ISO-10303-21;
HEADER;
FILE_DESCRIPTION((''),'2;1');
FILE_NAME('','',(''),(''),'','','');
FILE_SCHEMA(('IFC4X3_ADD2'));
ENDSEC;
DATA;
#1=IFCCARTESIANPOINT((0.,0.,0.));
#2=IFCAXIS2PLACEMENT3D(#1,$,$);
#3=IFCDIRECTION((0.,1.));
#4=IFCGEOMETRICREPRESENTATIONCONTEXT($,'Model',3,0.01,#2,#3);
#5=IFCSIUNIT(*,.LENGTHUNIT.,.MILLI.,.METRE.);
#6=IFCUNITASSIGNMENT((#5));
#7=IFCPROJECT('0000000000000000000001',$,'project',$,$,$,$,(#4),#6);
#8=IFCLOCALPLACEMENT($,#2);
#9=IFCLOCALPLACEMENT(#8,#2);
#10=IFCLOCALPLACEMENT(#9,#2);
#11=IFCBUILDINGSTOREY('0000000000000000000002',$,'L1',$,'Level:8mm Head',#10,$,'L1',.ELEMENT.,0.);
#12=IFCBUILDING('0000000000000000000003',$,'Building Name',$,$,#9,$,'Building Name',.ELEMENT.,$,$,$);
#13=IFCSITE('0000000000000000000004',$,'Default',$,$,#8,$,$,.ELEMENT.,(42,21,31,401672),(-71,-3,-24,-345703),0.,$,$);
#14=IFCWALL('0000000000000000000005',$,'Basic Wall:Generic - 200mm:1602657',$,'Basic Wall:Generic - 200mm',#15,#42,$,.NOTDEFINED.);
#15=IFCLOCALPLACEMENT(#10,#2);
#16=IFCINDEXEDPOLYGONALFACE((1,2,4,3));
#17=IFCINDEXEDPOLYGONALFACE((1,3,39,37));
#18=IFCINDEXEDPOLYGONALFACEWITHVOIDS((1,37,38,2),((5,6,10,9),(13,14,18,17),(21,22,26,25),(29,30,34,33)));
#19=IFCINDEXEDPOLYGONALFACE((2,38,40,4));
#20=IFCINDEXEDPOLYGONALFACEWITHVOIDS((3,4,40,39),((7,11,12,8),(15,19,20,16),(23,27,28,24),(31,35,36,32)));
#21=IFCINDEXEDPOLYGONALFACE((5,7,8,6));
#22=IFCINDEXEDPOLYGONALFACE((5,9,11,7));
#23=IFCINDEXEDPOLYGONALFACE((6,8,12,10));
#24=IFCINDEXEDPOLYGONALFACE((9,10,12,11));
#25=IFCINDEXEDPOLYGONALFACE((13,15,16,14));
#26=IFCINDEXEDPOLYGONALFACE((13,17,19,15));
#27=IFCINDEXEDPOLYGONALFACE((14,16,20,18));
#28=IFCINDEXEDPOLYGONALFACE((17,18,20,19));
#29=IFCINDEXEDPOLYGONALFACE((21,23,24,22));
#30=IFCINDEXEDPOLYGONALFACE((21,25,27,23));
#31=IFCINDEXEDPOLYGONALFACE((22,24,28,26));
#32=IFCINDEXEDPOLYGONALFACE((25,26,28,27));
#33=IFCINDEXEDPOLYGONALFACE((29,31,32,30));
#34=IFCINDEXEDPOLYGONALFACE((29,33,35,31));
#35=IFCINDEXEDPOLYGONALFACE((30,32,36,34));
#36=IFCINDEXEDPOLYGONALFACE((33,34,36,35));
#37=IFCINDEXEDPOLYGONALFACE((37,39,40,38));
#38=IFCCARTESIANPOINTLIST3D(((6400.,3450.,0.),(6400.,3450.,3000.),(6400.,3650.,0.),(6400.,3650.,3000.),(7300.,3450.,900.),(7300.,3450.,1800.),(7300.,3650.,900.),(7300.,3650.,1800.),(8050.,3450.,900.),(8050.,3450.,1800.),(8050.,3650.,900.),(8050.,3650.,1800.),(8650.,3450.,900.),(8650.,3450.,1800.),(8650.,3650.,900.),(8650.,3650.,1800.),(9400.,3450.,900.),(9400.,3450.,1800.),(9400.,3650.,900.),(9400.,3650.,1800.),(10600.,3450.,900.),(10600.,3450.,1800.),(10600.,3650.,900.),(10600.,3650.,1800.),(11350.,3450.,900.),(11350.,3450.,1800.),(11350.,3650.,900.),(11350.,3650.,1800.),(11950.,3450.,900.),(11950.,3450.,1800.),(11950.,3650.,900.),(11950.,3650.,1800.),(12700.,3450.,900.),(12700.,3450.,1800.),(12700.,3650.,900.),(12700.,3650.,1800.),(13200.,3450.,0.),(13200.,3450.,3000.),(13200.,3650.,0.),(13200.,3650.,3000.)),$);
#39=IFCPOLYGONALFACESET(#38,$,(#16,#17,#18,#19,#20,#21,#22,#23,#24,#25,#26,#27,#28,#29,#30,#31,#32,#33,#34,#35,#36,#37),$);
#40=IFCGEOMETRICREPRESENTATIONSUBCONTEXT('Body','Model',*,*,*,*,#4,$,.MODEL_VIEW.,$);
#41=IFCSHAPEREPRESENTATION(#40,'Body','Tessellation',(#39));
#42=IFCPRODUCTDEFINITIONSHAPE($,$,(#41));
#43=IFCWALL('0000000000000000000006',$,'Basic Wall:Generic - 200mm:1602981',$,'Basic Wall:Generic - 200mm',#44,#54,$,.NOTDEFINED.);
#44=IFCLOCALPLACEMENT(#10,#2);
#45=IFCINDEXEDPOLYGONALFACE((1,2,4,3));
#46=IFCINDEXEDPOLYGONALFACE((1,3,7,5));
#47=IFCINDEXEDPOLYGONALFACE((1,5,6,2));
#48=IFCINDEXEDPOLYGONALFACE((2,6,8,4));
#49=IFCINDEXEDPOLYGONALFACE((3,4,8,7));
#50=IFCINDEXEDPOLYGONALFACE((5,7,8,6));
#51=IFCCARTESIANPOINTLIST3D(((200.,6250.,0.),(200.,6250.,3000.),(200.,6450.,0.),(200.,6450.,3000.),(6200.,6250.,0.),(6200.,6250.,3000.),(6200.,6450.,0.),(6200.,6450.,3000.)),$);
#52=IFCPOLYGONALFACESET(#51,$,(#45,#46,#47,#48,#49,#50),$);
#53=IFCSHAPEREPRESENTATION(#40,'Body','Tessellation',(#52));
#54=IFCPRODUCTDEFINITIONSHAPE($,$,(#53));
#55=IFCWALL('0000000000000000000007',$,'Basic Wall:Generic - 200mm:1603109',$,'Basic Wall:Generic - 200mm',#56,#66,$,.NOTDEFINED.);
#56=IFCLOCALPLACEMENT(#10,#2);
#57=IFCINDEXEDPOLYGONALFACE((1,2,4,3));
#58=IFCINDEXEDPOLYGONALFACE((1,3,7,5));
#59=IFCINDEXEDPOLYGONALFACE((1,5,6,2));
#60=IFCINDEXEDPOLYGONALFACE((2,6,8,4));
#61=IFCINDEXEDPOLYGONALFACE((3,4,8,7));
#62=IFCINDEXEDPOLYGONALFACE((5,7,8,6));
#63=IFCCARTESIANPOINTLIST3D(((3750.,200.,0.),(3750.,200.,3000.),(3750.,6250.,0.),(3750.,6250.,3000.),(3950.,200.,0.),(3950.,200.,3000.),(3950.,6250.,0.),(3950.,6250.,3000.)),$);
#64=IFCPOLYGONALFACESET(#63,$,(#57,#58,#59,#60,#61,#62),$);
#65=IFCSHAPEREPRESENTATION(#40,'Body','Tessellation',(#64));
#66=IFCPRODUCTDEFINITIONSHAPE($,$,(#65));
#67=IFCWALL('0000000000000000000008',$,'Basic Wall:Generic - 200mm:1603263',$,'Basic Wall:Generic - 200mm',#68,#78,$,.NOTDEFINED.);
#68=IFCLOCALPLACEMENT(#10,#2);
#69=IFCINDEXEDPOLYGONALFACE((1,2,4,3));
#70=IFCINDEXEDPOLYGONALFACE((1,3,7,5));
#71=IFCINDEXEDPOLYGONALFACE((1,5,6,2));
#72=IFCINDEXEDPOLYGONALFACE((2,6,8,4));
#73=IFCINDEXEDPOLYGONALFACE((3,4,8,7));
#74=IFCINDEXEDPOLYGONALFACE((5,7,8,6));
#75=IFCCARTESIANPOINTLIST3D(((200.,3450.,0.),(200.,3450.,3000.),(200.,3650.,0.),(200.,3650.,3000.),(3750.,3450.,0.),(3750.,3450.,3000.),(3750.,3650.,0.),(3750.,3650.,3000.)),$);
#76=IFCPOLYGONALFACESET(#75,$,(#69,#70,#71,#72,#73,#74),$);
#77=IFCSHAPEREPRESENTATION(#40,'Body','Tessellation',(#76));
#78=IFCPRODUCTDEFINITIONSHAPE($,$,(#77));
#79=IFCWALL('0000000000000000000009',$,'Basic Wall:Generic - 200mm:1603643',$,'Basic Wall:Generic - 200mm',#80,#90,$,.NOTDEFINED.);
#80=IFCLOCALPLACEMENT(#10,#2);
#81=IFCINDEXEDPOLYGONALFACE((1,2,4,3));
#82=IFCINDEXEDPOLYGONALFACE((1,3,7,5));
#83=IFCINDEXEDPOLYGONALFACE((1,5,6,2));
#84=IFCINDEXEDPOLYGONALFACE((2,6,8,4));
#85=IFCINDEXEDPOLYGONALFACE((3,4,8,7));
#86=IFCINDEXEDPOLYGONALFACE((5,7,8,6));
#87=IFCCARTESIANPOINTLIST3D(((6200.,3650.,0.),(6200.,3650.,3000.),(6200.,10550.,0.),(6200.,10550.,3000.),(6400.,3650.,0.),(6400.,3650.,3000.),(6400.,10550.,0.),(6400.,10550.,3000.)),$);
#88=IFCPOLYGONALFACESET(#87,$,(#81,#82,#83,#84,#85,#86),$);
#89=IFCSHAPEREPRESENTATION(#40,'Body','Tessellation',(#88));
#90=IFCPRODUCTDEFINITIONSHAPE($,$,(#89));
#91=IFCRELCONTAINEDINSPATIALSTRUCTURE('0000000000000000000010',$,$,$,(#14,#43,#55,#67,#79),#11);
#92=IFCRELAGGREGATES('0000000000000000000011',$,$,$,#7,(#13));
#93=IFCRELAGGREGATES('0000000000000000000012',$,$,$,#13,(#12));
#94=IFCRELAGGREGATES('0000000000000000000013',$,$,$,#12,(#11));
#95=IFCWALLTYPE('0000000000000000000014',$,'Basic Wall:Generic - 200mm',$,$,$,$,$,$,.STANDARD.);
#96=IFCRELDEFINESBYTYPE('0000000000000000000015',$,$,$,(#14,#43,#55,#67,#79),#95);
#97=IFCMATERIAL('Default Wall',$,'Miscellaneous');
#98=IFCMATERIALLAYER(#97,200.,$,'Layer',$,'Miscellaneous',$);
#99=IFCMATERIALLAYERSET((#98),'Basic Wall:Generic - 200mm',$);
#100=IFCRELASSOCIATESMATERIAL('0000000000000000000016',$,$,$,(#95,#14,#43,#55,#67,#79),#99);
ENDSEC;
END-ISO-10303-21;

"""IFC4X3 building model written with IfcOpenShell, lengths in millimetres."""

from ifc_helpers import new_model, si_unit, direction, frame, frame_2d, origin, place, context, subcontext, project, spatial, rectangle, extrude, material, layer, layer_set, type_object, element, save


model = new_model("IFC4X3")

# Units and contexts
model_context = context("Model", 3, precision=0.01, world=origin(), true_north=direction((0.0, 1.0)))
body_context = subcontext(model_context, "Body", "Model", "MODEL_VIEW")
ifc_project = project(units=[si_unit("LENGTHUNIT", "METRE", prefix="MILLI")], contexts=[model_context])

# Site, building, storey
site_placement = place(None, origin())
site = spatial("IfcSite", under=ifc_project, at=site_placement, Name="Default", CompositionType="ELEMENT", RefLatitude=(42, 21, 31, 401672), RefLongitude=(-71, -3, -24, -345703), RefElevation=0.0)
building_placement = place(site_placement, origin())
building = spatial("IfcBuilding", under=site, at=building_placement, Name="Building Name", LongName="Building Name", CompositionType="ELEMENT")
storey_placement = place(building_placement, origin())
storey = spatial("IfcBuildingStorey", under=building, at=storey_placement, Name="L1", ObjectType="Level:8mm Head", LongName="L1", CompositionType="ELEMENT", Elevation=0.0)

# Shared definitions
ifc_material = material(Name="Default Wall", Category="Miscellaneous")
ifc_layer = layer(ifc_material, 200.0, Name="Layer", Category="Miscellaneous")
ifc_layer_set = layer_set([ifc_layer], Name="Basic Wall:Generic - 200mm")
wall_type = type_object("IfcWallType", Name="Basic Wall:Generic - 200mm", PredefinedType="STANDARD", material=ifc_layer_set)

# Wall, openings
wall_1_placement = place(storey_placement, frame((6400.0, 3550.0, 0.0)))
wall_1 = element("IfcWall", 1, at=wall_1_placement, inside=storey, type_object=wall_type, material=ifc_layer_set, Name="Basic Wall:Generic - 200mm:1602657", ObjectType="Basic Wall:Generic - 200mm", PredefinedType="NOTDEFINED", context=body_context, shape_type="SweptSolid", body=[
    extrude(rectangle(XDim=6800.0, YDim=200.0, at=frame_2d((3400.0, 0.0), x_axis=(-1.0, 0.0))), origin(), (0.0, 0.0, 1.0), 3000.0),
])
opening_1_placement = place(wall_1_placement, frame((1650.0, 100.0, 900.0)))
element("IfcOpeningElement", 2, at=opening_1_placement, cuts=wall_1, PredefinedType="OPENING", context=body_context, shape_type="SweptSolid", body=[
    extrude(rectangle(XDim=900.0, YDim=750.0, at=frame_2d((450.0, 375.0), x_axis=(-1.0, 0.0))), frame((0.0, 0.0, 0.0), z_axis=(0.0, -1.0, 0.0), x_axis=(0.0, 0.0, 1.0)), (0.0, 0.0, 1.0), 200.0),
])
opening_2_placement = place(wall_1_placement, frame((3000.0, 100.0, 900.0)))
element("IfcOpeningElement", 3, at=opening_2_placement, cuts=wall_1, PredefinedType="OPENING", context=body_context, shape_type="SweptSolid", body=[
    extrude(rectangle(XDim=900.0, YDim=750.0, at=frame_2d((450.0, 375.0), x_axis=(-1.0, 0.0))), frame((0.0, 0.0, 0.0), z_axis=(0.0, -1.0, 0.0), x_axis=(0.0, 0.0, 1.0)), (0.0, 0.0, 1.0), 200.0),
])
opening_3_placement = place(wall_1_placement, frame((4950.0, 100.0, 900.0)))
element("IfcOpeningElement", 4, at=opening_3_placement, cuts=wall_1, PredefinedType="OPENING", context=body_context, shape_type="SweptSolid", body=[
    extrude(rectangle(XDim=900.0, YDim=750.0, at=frame_2d((450.0, 375.0), x_axis=(-1.0, 0.0))), frame((0.0, 0.0, 0.0), z_axis=(0.0, -1.0, 0.0), x_axis=(0.0, 0.0, 1.0)), (0.0, 0.0, 1.0), 200.0),
])
opening_4_placement = place(wall_1_placement, frame((6300.0, 100.0, 900.0)))
element("IfcOpeningElement", 5, at=opening_4_placement, cuts=wall_1, PredefinedType="OPENING", context=body_context, shape_type="SweptSolid", body=[
    extrude(rectangle(XDim=900.0, YDim=750.0, at=frame_2d((450.0, 375.0), x_axis=(-1.0, 0.0))), frame((0.0, 0.0, 0.0), z_axis=(0.0, -1.0, 0.0), x_axis=(0.0, 0.0, 1.0)), (0.0, 0.0, 1.0), 200.0),
])

# Walls
wall_2_placement = place(storey_placement, frame((6200.0, 6350.0, 0.0), z_axis=(0.0, 0.0, 1.0), x_axis=(-1.0, 0.0, 0.0)))
element("IfcWall", 6, at=wall_2_placement, inside=storey, type_object=wall_type, material=ifc_layer_set, Name="Basic Wall:Generic - 200mm:1602981", ObjectType="Basic Wall:Generic - 200mm", PredefinedType="NOTDEFINED", context=body_context, shape_type="SweptSolid", body=[
    extrude(rectangle(XDim=6000.0, YDim=200.0, at=frame_2d((3000.0, 0.0), x_axis=(-1.0, 0.0))), origin(), (0.0, 0.0, 1.0), 3000.0),
])
wall_3_placement = place(storey_placement, frame((3850.0, 6250.0, 0.0), z_axis=(0.0, 0.0, 1.0), x_axis=(0.0, -1.0, 0.0)))
element("IfcWall", 7, at=wall_3_placement, inside=storey, type_object=wall_type, material=ifc_layer_set, Name="Basic Wall:Generic - 200mm:1603109", ObjectType="Basic Wall:Generic - 200mm", PredefinedType="NOTDEFINED", context=body_context, shape_type="SweptSolid", body=[
    extrude(rectangle(XDim=6050.0, YDim=200.0, at=frame_2d((3025.0, 0.0), x_axis=(-1.0, 0.0))), origin(), (0.0, 0.0, 1.0), 3000.0),
])
wall_4_placement = place(storey_placement, frame((3750.0, 3550.0, 0.0), z_axis=(0.0, 0.0, 1.0), x_axis=(-1.0, 0.0, 0.0)))
element("IfcWall", 8, at=wall_4_placement, inside=storey, type_object=wall_type, material=ifc_layer_set, Name="Basic Wall:Generic - 200mm:1603263", ObjectType="Basic Wall:Generic - 200mm", PredefinedType="NOTDEFINED", context=body_context, shape_type="SweptSolid", body=[
    extrude(rectangle(XDim=3550.0, YDim=200.0, at=frame_2d((1775.0, 0.0), x_axis=(-1.0, 0.0))), origin(), (0.0, 0.0, 1.0), 3000.0),
])
wall_5_placement = place(storey_placement, frame((6300.0, 3650.0, 0.0), z_axis=(0.0, 0.0, 1.0), x_axis=(0.0, 1.0, 0.0)))
element("IfcWall", 9, at=wall_5_placement, inside=storey, type_object=wall_type, material=ifc_layer_set, Name="Basic Wall:Generic - 200mm:1603643", ObjectType="Basic Wall:Generic - 200mm", PredefinedType="NOTDEFINED", context=body_context, shape_type="SweptSolid", body=[
    extrude(rectangle(XDim=6900.0, YDim=200.0, at=frame_2d((3450.0, 0.0), x_axis=(-1.0, 0.0))), origin(), (0.0, 0.0, 1.0), 3000.0),
])

save(model, "model.ifc")
